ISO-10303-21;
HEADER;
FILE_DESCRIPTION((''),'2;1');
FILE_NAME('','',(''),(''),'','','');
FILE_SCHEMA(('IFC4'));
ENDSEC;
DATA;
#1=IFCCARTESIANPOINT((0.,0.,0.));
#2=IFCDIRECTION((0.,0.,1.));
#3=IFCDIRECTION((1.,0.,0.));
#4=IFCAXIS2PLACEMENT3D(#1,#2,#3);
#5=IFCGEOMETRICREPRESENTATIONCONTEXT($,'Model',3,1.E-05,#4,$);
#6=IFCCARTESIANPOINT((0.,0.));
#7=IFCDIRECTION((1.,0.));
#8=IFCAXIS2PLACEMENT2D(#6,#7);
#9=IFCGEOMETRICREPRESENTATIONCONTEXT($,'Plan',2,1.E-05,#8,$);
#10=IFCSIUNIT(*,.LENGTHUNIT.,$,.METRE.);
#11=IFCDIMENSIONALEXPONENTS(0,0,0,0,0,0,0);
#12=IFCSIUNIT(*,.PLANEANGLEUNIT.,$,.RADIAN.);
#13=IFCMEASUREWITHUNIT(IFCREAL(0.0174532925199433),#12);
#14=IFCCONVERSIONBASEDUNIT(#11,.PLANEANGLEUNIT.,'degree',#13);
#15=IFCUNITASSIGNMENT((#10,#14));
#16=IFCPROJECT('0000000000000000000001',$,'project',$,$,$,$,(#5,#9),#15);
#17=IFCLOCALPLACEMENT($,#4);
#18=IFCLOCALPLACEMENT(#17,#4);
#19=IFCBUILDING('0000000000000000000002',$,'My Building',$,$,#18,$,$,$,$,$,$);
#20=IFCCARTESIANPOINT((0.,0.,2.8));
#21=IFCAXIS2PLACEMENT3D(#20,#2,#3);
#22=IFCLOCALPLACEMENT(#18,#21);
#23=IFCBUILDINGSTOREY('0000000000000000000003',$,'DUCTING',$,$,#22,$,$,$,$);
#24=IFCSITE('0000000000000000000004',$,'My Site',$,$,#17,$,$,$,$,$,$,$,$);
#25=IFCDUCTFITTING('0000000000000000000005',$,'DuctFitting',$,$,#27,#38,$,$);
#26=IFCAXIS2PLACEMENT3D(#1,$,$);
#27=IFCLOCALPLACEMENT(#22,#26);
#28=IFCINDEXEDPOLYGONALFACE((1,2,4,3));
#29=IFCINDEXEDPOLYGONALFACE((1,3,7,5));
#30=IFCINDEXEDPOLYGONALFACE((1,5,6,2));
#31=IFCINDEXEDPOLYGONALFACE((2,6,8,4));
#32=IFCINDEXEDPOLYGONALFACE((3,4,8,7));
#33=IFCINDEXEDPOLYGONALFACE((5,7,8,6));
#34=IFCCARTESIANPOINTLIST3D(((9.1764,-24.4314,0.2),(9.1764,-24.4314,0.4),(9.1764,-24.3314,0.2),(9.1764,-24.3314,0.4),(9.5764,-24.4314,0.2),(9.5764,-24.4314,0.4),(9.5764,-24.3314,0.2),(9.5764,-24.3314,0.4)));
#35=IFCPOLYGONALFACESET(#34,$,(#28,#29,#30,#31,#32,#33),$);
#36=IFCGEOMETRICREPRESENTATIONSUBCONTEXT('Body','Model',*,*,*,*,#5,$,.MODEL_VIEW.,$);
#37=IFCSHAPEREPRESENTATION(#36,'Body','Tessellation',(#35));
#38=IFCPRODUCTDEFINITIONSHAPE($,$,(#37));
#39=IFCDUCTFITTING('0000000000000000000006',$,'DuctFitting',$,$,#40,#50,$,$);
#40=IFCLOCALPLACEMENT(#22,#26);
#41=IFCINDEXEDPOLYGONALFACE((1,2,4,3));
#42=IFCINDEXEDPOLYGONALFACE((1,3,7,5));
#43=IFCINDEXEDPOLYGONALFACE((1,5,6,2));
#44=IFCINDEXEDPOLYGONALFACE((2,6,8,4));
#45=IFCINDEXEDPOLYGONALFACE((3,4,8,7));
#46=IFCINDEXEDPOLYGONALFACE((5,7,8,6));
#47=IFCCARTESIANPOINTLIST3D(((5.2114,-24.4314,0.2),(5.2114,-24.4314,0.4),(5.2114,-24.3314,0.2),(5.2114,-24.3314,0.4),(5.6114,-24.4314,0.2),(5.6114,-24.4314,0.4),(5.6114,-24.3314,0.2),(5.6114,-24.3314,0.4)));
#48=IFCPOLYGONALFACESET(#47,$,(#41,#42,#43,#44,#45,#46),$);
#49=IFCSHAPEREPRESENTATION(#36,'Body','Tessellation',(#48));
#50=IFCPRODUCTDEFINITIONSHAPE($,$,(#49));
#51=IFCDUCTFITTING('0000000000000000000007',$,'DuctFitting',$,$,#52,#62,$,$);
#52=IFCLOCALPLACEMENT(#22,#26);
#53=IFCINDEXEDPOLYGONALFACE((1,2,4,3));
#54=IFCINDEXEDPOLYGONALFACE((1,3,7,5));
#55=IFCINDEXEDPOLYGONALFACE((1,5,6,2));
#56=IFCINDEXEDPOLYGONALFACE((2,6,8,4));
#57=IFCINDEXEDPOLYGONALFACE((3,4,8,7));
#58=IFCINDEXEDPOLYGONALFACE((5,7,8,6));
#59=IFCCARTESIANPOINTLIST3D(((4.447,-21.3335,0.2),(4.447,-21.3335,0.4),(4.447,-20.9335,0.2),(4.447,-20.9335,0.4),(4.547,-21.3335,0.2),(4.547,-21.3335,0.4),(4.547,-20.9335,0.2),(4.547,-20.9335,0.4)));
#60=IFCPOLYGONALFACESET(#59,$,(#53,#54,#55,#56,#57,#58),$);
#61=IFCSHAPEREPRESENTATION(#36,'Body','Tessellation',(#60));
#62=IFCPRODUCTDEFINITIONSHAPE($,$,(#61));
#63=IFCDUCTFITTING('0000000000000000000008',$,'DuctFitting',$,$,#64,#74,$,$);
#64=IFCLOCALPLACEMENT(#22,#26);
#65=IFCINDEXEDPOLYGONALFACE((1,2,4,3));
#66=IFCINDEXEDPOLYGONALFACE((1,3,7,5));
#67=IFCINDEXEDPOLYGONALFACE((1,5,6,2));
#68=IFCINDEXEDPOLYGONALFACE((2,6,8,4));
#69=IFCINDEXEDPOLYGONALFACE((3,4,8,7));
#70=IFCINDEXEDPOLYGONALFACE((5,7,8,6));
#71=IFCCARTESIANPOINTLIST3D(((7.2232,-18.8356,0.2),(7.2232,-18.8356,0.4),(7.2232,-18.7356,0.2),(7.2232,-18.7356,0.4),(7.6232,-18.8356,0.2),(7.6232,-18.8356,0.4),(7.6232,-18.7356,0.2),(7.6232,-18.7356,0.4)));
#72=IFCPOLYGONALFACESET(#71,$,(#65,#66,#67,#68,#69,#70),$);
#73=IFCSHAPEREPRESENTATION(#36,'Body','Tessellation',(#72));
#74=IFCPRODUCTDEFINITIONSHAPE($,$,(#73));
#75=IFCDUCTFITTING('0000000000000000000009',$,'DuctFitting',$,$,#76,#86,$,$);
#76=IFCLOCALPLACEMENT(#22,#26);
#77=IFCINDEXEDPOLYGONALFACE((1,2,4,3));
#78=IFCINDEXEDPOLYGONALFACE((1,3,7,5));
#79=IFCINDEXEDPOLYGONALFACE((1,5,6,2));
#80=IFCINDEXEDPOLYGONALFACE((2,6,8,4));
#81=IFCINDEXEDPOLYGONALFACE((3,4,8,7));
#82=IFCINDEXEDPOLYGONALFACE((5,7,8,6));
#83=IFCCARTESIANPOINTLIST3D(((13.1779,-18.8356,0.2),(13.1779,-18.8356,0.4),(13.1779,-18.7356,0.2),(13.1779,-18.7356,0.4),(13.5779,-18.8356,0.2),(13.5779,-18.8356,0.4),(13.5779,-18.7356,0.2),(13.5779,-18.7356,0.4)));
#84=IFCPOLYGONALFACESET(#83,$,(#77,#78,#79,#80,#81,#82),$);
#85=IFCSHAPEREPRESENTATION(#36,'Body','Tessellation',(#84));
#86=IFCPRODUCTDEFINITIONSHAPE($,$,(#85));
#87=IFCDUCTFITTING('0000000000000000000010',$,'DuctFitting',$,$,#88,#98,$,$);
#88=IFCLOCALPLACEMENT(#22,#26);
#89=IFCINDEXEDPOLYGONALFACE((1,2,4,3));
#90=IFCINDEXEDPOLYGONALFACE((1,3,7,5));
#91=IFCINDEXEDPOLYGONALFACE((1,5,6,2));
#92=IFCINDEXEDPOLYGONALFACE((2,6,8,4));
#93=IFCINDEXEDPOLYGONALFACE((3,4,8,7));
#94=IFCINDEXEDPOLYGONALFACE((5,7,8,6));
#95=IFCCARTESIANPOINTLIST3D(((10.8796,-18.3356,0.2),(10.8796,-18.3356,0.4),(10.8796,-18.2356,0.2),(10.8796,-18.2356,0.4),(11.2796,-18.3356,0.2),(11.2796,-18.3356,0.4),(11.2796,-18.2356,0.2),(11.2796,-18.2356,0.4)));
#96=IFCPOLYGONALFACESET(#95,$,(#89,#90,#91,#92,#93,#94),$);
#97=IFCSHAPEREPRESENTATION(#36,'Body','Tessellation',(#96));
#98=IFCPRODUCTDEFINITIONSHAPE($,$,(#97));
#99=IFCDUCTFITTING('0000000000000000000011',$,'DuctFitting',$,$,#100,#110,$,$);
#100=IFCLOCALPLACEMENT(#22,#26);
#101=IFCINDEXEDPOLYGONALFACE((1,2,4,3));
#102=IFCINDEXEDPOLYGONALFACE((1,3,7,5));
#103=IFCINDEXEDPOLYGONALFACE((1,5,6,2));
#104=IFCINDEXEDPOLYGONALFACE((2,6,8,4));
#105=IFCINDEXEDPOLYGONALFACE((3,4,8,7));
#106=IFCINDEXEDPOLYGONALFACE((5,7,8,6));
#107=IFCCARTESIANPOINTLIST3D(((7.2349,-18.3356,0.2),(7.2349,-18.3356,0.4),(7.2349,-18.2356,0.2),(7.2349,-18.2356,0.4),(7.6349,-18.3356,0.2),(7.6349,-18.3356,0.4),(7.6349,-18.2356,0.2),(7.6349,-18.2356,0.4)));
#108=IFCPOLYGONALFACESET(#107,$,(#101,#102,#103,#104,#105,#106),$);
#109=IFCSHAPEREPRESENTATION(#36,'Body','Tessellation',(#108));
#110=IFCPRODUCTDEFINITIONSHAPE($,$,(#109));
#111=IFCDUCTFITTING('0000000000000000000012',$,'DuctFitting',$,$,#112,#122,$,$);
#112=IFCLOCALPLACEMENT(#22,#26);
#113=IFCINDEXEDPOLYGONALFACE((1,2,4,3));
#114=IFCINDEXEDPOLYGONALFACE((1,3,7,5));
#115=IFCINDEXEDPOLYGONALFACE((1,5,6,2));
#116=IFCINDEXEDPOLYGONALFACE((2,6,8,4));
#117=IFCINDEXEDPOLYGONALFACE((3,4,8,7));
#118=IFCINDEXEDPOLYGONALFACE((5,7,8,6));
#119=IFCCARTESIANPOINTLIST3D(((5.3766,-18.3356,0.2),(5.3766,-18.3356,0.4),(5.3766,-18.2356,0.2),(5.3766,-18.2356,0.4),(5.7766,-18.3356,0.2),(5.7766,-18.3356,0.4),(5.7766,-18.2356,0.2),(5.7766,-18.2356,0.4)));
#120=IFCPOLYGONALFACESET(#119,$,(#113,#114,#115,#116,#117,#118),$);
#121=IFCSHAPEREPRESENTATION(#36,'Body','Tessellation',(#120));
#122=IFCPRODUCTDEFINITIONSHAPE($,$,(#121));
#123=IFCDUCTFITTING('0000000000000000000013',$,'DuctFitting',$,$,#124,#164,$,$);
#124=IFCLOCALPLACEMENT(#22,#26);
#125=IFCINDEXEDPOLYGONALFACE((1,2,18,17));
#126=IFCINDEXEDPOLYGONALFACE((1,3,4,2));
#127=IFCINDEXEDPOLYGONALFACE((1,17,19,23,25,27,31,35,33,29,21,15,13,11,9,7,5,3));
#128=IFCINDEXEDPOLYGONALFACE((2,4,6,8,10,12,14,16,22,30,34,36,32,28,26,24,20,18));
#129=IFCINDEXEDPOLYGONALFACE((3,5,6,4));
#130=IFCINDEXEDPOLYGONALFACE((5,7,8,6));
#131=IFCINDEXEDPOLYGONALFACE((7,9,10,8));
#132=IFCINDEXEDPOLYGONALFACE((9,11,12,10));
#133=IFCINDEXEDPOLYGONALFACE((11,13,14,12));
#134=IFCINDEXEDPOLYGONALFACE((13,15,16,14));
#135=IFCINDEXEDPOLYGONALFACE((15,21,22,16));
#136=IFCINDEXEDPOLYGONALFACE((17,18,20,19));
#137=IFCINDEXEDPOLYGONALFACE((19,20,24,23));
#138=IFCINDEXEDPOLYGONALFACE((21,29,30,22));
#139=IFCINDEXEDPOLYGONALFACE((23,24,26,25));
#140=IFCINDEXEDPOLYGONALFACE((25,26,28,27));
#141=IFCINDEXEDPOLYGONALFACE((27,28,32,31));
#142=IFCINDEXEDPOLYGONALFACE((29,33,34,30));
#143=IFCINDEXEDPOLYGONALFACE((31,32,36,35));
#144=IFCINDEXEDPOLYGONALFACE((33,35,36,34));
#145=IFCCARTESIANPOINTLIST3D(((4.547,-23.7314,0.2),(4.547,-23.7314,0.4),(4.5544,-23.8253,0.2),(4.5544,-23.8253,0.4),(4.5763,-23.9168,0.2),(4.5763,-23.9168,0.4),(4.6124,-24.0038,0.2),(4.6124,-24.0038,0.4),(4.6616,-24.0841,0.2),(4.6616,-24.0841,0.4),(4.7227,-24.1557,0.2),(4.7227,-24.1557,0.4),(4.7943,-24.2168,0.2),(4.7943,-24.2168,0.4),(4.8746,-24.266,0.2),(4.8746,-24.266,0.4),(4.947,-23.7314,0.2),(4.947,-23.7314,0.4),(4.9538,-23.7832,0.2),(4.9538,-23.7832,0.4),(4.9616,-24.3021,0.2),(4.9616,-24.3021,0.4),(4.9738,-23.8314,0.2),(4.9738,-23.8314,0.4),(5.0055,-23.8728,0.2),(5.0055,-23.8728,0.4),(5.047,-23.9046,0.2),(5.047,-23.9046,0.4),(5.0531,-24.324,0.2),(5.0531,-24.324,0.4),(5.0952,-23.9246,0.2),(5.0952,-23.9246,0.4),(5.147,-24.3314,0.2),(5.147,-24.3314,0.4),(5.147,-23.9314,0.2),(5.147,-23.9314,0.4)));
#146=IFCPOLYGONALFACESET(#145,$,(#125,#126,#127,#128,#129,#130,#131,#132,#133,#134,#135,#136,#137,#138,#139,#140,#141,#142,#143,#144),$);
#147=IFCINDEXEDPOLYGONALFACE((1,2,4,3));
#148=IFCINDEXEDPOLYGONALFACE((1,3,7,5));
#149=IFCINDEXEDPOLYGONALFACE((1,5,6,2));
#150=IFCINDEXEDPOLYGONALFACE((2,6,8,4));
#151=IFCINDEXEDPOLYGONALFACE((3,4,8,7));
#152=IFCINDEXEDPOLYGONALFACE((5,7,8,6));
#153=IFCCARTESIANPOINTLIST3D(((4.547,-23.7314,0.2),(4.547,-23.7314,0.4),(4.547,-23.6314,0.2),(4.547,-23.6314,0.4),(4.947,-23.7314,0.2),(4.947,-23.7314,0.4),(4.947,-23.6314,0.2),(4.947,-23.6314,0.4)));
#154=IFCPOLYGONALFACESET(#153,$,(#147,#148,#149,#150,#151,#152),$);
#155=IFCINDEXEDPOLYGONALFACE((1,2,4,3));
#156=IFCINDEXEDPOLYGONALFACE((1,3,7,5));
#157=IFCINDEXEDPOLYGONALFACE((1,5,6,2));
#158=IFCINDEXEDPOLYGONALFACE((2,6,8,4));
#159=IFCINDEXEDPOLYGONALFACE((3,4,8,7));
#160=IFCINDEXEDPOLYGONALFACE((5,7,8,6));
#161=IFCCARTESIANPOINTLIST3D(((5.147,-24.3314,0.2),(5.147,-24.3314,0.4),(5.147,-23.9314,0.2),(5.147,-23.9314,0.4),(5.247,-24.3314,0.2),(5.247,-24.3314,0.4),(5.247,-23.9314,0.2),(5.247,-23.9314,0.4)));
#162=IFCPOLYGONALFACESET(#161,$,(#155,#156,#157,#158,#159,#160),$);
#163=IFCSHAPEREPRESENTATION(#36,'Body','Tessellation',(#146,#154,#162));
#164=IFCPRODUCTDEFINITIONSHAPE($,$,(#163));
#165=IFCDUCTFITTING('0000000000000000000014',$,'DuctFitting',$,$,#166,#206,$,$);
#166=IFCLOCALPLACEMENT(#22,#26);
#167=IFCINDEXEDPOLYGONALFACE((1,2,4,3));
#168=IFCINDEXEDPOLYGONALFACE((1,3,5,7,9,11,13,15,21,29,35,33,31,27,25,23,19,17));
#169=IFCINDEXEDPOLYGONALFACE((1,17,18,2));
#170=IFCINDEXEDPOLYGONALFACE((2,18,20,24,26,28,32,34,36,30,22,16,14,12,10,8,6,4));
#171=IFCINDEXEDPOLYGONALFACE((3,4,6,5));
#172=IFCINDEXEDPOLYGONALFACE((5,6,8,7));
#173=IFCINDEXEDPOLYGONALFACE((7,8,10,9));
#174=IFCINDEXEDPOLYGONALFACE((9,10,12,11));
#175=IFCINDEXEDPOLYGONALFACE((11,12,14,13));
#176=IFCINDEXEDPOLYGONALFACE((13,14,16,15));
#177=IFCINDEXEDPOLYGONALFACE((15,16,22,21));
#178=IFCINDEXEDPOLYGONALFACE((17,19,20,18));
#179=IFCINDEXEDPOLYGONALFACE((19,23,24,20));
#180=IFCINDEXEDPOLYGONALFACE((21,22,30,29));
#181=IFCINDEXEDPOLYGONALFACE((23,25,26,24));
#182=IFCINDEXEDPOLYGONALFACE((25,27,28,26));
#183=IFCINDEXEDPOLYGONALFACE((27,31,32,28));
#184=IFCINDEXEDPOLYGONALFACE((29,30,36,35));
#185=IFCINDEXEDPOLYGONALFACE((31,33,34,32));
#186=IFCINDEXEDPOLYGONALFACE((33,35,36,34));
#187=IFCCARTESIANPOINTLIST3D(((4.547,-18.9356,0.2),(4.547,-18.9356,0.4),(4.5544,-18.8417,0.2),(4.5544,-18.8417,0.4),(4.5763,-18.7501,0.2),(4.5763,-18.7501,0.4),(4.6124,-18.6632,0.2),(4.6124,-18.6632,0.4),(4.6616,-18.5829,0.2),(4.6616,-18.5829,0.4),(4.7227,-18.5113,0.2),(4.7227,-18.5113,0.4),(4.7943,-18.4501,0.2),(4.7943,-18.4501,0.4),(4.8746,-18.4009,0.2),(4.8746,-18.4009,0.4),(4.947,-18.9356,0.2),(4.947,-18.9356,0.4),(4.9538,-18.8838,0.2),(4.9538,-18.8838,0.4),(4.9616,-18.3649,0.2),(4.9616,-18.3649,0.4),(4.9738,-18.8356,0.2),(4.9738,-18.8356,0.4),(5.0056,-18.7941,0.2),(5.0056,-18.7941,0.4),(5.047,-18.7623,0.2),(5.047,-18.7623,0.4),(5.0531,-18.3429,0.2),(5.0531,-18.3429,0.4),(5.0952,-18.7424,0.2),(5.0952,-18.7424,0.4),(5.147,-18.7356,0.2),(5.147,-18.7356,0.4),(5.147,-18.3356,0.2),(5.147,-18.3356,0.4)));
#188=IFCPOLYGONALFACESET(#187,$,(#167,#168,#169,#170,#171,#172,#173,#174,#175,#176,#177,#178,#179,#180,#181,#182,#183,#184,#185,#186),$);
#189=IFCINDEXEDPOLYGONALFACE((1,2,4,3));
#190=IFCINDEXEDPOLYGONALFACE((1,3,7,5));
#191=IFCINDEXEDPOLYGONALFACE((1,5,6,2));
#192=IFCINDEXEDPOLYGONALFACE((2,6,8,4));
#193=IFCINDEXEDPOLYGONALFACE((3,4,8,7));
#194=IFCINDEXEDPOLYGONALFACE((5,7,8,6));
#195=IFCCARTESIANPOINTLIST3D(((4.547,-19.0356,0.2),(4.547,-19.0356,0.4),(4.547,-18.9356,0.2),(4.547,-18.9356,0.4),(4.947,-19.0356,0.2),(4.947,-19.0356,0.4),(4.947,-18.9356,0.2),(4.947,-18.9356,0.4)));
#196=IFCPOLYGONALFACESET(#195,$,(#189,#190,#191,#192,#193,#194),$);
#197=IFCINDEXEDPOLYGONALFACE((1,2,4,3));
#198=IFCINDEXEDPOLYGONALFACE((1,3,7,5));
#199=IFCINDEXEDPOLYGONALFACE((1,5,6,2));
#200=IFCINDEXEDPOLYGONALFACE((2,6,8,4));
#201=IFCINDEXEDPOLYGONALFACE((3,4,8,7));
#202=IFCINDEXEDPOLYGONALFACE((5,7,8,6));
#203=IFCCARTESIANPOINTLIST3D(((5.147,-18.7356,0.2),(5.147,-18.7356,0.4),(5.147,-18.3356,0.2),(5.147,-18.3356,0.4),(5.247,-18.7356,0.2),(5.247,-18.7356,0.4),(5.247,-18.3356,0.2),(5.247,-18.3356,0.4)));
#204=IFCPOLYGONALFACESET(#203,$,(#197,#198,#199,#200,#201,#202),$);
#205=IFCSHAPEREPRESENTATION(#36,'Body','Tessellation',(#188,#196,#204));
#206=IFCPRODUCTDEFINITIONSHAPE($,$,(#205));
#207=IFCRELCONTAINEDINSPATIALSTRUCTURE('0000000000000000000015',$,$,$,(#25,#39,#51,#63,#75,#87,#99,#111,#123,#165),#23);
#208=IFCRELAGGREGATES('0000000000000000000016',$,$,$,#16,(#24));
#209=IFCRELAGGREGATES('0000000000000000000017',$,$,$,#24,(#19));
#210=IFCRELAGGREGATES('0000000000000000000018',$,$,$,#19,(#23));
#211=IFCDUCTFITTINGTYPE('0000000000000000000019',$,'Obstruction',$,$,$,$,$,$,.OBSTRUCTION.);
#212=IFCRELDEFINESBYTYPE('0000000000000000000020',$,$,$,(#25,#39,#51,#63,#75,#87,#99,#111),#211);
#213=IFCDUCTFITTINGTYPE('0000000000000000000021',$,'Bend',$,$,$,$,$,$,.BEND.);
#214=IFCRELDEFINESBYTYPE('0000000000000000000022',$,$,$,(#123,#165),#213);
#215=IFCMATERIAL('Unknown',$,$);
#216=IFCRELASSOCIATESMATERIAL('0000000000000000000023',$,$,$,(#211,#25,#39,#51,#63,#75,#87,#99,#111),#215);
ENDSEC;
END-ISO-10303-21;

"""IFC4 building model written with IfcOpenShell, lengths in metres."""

from ifc_helpers import new_model, entity, si_unit, converted_unit, frame, origin_with_axes, origin_2d_with_axis, place, context, subcontext, project, spatial, line, arc, indexed_curve, rectangle, outline, extrude, source, transform, mapped, material, material_profile, profile_set, profile_usage, type_object, type_shapes, element, save


model = new_model("IFC4")

# Units and contexts
model_context = context("Model", 3, precision=1e-05, world=origin_with_axes())
plan_context = context("Plan", 2, precision=1e-05, world=origin_2d_with_axis())
body_context = subcontext(model_context, "Body", "Model", "MODEL_VIEW")
ifc_project = project(units=[si_unit("LENGTHUNIT", "METRE"), converted_unit("PLANEANGLEUNIT", "degree", entity("IfcReal", 0.0174532925199433), si_unit("PLANEANGLEUNIT", "RADIAN"), dimensions=[0, 0, 0, 0, 0, 0, 0])], contexts=[model_context, plan_context])

# Site, building, storey
site_placement = place(None, origin_with_axes())
site = spatial("IfcSite", under=ifc_project, at=site_placement, Name="My Site")
building_placement = place(site_placement, origin_with_axes())
building = spatial("IfcBuilding", under=site, at=building_placement, Name="My Building")
storey_placement = place(building_placement, frame((0.0, 0.0, 2.8), z_axis=(0.0, 0.0, 1.0), x_axis=(1.0, 0.0, 0.0)))
storey = spatial("IfcBuildingStorey", under=building, at=storey_placement, Name="DUCTING")

# Shared definitions
ifc_material = material(Name="Unknown")

# Duct fittings
ifc_material_profile_1 = material_profile(ifc_material, rectangle(XDim=0.4, YDim=0.2))
ifc_profile_set_1 = profile_set([ifc_material_profile_1])
duct_fitting_type_1 = type_object("IfcDuctFittingType", Name="Obstruction", PredefinedType="OBSTRUCTION", material=ifc_profile_set_1)
ifc_profile_usage_1 = profile_usage(ifc_profile_set_1, cardinal=5)
duct_fitting_1_placement = place(storey_placement, frame((9.3764, -24.3314, 0.3), z_axis=(0.0, -1.0, 0.0), x_axis=(1.0, 0.0, 0.0)))
element("IfcDuctFitting", 1, at=duct_fitting_1_placement, inside=storey, type_object=duct_fitting_type_1, material=ifc_profile_usage_1, Name="DuctFitting", context=body_context, shape_type="SweptSolid", body=[
    extrude(rectangle(XDim=0.4, YDim=0.2), origin_with_axes(), (0.0, 0.0, 1.0), 0.1),
])
ifc_profile_usage_2 = profile_usage(ifc_profile_set_1, cardinal=5)
duct_fitting_2_placement = place(storey_placement, frame((5.4114, -24.3314, 0.3), z_axis=(0.0, -1.0, 0.0), x_axis=(1.0, 0.0, 0.0)))
element("IfcDuctFitting", 2, at=duct_fitting_2_placement, inside=storey, type_object=duct_fitting_type_1, material=ifc_profile_usage_2, Name="DuctFitting", context=body_context, shape_type="SweptSolid", body=[
    extrude(rectangle(XDim=0.4, YDim=0.2), origin_with_axes(), (0.0, 0.0, 1.0), 0.1),
])
ifc_profile_usage_3 = profile_usage(ifc_profile_set_1, cardinal=5)
duct_fitting_3_placement = place(storey_placement, frame((4.447, -21.1335, 0.3), z_axis=(1.0, 0.000001, 0.000001), x_axis=(-0.000001, 1.0, 0.0)))
element("IfcDuctFitting", 3, at=duct_fitting_3_placement, inside=storey, type_object=duct_fitting_type_1, material=ifc_profile_usage_3, Name="DuctFitting", context=body_context, shape_type="SweptSolid", body=[
    extrude(rectangle(XDim=0.4, YDim=0.2), origin_with_axes(), (0.0, 0.0, 1.0), 0.1),
])
ifc_profile_usage_4 = profile_usage(ifc_profile_set_1, cardinal=5)
duct_fitting_4_placement = place(storey_placement, frame((7.4232, -18.7356, 0.3), z_axis=(0.0, -1.0, 0.0), x_axis=(1.0, 0.0, 0.0)))
element("IfcDuctFitting", 4, at=duct_fitting_4_placement, inside=storey, type_object=duct_fitting_type_1, material=ifc_profile_usage_4, Name="DuctFitting", context=body_context, shape_type="SweptSolid", body=[
    extrude(rectangle(XDim=0.4, YDim=0.2), origin_with_axes(), (0.0, 0.0, 1.0), 0.1),
])
ifc_profile_usage_5 = profile_usage(ifc_profile_set_1, cardinal=5)
duct_fitting_5_placement = place(storey_placement, frame((13.3779, -18.7356, 0.3), z_axis=(0.0, -1.0, 0.0), x_axis=(1.0, 0.0, 0.0)))
element("IfcDuctFitting", 5, at=duct_fitting_5_placement, inside=storey, type_object=duct_fitting_type_1, material=ifc_profile_usage_5, Name="DuctFitting", context=body_context, shape_type="SweptSolid", body=[
    extrude(rectangle(XDim=0.4, YDim=0.2), origin_with_axes(), (0.0, 0.0, 1.0), 0.1),
])
ifc_profile_usage_6 = profile_usage(ifc_profile_set_1, cardinal=5)
duct_fitting_6_placement = place(storey_placement, frame((11.0796, -18.2356, 0.3), z_axis=(0.0, -1.0, 0.0), x_axis=(1.0, 0.0, 0.0)))
element("IfcDuctFitting", 6, at=duct_fitting_6_placement, inside=storey, type_object=duct_fitting_type_1, material=ifc_profile_usage_6, Name="DuctFitting", context=body_context, shape_type="SweptSolid", body=[
    extrude(rectangle(XDim=0.4, YDim=0.2), origin_with_axes(), (0.0, 0.0, 1.0), 0.1),
])
ifc_profile_usage_7 = profile_usage(ifc_profile_set_1, cardinal=5)
duct_fitting_7_placement = place(storey_placement, frame((7.4349, -18.2356, 0.3), z_axis=(0.0, -1.0, 0.0), x_axis=(1.0, 0.0, 0.0)))
element("IfcDuctFitting", 7, at=duct_fitting_7_placement, inside=storey, type_object=duct_fitting_type_1, material=ifc_profile_usage_7, Name="DuctFitting", context=body_context, shape_type="SweptSolid", body=[
    extrude(rectangle(XDim=0.4, YDim=0.2), origin_with_axes(), (0.0, 0.0, 1.0), 0.1),
])
ifc_profile_usage_8 = profile_usage(ifc_profile_set_1, cardinal=5)
duct_fitting_8_placement = place(storey_placement, frame((5.5766, -18.2356, 0.3), z_axis=(0.0, -1.0, 0.0), x_axis=(1.0, 0.0, 0.0)))
element("IfcDuctFitting", 8, at=duct_fitting_8_placement, inside=storey, type_object=duct_fitting_type_1, material=ifc_profile_usage_8, Name="DuctFitting", context=body_context, shape_type="SweptSolid", body=[
    extrude(rectangle(XDim=0.4, YDim=0.2), origin_with_axes(), (0.0, 0.0, 1.0), 0.1),
])
duct_fitting_type_2 = type_object("IfcDuctFittingType", Name="Bend", PredefinedType="BEND")
shared_shape = source(origin_with_axes(), body_context, "Body", "SweptSolid", [
    extrude(outline(indexed_curve([(0.2, 0.0), (0.2586, -0.1414), (0.4, -0.2), (0.4, -0.6), (-0.0243, -0.4243), (-0.2, 0.0)], segments=[arc(1, 2, 3), line(3, 4), arc(4, 5, 6), line(6, 1)])), frame((0.0, -0.1, -0.1), z_axis=(0.0, -1.0, 0.0), x_axis=(1.0, 0.0, 0.0)), (0.0, 0.0, -1.0), 0.2),
    extrude(rectangle(XDim=0.4, YDim=0.2), origin_with_axes(), (0.0, 0.0, -1.0), 0.1),
    extrude(rectangle(XDim=0.4, YDim=0.2), frame((0.4, 0.0, -0.5), z_axis=(1.0, 0.0, 0.0), x_axis=(0.0, 0.0, 1.0)), (0.0, 0.0, 1.0), 0.1),
])
type_shapes(duct_fitting_type_2, [shared_shape])
for number, where, z_axis, x_axis, name in (
    (9, (4.747, -23.6314, 0.3), (0.0, 1.0, 0.000001), (1.0, 0.0, 0.0), "DuctFitting"),
    (10, (4.747, -19.0356, 0.3), (0.0, -1.0, -0.000001), (1.0, 0.0, 0.0), "DuctFitting"),
):
    element("IfcDuctFitting", number, at=place(storey_placement, frame(where, z_axis=z_axis, x_axis=x_axis)), inside=storey, type_object=duct_fitting_type_2, Name=name, context=body_context, shape_type="MappedRepresentation", body=[
        mapped(shared_shape, transform((0.0, 0.0, 0.0), x_axis=(1.0, 0.0, 0.0), y_axis=(0.0, 1.0, 0.0), z_axis=(0.0, 0.0, 1.0), scale=1.0)),
    ])

save(model, "model.ifc")
